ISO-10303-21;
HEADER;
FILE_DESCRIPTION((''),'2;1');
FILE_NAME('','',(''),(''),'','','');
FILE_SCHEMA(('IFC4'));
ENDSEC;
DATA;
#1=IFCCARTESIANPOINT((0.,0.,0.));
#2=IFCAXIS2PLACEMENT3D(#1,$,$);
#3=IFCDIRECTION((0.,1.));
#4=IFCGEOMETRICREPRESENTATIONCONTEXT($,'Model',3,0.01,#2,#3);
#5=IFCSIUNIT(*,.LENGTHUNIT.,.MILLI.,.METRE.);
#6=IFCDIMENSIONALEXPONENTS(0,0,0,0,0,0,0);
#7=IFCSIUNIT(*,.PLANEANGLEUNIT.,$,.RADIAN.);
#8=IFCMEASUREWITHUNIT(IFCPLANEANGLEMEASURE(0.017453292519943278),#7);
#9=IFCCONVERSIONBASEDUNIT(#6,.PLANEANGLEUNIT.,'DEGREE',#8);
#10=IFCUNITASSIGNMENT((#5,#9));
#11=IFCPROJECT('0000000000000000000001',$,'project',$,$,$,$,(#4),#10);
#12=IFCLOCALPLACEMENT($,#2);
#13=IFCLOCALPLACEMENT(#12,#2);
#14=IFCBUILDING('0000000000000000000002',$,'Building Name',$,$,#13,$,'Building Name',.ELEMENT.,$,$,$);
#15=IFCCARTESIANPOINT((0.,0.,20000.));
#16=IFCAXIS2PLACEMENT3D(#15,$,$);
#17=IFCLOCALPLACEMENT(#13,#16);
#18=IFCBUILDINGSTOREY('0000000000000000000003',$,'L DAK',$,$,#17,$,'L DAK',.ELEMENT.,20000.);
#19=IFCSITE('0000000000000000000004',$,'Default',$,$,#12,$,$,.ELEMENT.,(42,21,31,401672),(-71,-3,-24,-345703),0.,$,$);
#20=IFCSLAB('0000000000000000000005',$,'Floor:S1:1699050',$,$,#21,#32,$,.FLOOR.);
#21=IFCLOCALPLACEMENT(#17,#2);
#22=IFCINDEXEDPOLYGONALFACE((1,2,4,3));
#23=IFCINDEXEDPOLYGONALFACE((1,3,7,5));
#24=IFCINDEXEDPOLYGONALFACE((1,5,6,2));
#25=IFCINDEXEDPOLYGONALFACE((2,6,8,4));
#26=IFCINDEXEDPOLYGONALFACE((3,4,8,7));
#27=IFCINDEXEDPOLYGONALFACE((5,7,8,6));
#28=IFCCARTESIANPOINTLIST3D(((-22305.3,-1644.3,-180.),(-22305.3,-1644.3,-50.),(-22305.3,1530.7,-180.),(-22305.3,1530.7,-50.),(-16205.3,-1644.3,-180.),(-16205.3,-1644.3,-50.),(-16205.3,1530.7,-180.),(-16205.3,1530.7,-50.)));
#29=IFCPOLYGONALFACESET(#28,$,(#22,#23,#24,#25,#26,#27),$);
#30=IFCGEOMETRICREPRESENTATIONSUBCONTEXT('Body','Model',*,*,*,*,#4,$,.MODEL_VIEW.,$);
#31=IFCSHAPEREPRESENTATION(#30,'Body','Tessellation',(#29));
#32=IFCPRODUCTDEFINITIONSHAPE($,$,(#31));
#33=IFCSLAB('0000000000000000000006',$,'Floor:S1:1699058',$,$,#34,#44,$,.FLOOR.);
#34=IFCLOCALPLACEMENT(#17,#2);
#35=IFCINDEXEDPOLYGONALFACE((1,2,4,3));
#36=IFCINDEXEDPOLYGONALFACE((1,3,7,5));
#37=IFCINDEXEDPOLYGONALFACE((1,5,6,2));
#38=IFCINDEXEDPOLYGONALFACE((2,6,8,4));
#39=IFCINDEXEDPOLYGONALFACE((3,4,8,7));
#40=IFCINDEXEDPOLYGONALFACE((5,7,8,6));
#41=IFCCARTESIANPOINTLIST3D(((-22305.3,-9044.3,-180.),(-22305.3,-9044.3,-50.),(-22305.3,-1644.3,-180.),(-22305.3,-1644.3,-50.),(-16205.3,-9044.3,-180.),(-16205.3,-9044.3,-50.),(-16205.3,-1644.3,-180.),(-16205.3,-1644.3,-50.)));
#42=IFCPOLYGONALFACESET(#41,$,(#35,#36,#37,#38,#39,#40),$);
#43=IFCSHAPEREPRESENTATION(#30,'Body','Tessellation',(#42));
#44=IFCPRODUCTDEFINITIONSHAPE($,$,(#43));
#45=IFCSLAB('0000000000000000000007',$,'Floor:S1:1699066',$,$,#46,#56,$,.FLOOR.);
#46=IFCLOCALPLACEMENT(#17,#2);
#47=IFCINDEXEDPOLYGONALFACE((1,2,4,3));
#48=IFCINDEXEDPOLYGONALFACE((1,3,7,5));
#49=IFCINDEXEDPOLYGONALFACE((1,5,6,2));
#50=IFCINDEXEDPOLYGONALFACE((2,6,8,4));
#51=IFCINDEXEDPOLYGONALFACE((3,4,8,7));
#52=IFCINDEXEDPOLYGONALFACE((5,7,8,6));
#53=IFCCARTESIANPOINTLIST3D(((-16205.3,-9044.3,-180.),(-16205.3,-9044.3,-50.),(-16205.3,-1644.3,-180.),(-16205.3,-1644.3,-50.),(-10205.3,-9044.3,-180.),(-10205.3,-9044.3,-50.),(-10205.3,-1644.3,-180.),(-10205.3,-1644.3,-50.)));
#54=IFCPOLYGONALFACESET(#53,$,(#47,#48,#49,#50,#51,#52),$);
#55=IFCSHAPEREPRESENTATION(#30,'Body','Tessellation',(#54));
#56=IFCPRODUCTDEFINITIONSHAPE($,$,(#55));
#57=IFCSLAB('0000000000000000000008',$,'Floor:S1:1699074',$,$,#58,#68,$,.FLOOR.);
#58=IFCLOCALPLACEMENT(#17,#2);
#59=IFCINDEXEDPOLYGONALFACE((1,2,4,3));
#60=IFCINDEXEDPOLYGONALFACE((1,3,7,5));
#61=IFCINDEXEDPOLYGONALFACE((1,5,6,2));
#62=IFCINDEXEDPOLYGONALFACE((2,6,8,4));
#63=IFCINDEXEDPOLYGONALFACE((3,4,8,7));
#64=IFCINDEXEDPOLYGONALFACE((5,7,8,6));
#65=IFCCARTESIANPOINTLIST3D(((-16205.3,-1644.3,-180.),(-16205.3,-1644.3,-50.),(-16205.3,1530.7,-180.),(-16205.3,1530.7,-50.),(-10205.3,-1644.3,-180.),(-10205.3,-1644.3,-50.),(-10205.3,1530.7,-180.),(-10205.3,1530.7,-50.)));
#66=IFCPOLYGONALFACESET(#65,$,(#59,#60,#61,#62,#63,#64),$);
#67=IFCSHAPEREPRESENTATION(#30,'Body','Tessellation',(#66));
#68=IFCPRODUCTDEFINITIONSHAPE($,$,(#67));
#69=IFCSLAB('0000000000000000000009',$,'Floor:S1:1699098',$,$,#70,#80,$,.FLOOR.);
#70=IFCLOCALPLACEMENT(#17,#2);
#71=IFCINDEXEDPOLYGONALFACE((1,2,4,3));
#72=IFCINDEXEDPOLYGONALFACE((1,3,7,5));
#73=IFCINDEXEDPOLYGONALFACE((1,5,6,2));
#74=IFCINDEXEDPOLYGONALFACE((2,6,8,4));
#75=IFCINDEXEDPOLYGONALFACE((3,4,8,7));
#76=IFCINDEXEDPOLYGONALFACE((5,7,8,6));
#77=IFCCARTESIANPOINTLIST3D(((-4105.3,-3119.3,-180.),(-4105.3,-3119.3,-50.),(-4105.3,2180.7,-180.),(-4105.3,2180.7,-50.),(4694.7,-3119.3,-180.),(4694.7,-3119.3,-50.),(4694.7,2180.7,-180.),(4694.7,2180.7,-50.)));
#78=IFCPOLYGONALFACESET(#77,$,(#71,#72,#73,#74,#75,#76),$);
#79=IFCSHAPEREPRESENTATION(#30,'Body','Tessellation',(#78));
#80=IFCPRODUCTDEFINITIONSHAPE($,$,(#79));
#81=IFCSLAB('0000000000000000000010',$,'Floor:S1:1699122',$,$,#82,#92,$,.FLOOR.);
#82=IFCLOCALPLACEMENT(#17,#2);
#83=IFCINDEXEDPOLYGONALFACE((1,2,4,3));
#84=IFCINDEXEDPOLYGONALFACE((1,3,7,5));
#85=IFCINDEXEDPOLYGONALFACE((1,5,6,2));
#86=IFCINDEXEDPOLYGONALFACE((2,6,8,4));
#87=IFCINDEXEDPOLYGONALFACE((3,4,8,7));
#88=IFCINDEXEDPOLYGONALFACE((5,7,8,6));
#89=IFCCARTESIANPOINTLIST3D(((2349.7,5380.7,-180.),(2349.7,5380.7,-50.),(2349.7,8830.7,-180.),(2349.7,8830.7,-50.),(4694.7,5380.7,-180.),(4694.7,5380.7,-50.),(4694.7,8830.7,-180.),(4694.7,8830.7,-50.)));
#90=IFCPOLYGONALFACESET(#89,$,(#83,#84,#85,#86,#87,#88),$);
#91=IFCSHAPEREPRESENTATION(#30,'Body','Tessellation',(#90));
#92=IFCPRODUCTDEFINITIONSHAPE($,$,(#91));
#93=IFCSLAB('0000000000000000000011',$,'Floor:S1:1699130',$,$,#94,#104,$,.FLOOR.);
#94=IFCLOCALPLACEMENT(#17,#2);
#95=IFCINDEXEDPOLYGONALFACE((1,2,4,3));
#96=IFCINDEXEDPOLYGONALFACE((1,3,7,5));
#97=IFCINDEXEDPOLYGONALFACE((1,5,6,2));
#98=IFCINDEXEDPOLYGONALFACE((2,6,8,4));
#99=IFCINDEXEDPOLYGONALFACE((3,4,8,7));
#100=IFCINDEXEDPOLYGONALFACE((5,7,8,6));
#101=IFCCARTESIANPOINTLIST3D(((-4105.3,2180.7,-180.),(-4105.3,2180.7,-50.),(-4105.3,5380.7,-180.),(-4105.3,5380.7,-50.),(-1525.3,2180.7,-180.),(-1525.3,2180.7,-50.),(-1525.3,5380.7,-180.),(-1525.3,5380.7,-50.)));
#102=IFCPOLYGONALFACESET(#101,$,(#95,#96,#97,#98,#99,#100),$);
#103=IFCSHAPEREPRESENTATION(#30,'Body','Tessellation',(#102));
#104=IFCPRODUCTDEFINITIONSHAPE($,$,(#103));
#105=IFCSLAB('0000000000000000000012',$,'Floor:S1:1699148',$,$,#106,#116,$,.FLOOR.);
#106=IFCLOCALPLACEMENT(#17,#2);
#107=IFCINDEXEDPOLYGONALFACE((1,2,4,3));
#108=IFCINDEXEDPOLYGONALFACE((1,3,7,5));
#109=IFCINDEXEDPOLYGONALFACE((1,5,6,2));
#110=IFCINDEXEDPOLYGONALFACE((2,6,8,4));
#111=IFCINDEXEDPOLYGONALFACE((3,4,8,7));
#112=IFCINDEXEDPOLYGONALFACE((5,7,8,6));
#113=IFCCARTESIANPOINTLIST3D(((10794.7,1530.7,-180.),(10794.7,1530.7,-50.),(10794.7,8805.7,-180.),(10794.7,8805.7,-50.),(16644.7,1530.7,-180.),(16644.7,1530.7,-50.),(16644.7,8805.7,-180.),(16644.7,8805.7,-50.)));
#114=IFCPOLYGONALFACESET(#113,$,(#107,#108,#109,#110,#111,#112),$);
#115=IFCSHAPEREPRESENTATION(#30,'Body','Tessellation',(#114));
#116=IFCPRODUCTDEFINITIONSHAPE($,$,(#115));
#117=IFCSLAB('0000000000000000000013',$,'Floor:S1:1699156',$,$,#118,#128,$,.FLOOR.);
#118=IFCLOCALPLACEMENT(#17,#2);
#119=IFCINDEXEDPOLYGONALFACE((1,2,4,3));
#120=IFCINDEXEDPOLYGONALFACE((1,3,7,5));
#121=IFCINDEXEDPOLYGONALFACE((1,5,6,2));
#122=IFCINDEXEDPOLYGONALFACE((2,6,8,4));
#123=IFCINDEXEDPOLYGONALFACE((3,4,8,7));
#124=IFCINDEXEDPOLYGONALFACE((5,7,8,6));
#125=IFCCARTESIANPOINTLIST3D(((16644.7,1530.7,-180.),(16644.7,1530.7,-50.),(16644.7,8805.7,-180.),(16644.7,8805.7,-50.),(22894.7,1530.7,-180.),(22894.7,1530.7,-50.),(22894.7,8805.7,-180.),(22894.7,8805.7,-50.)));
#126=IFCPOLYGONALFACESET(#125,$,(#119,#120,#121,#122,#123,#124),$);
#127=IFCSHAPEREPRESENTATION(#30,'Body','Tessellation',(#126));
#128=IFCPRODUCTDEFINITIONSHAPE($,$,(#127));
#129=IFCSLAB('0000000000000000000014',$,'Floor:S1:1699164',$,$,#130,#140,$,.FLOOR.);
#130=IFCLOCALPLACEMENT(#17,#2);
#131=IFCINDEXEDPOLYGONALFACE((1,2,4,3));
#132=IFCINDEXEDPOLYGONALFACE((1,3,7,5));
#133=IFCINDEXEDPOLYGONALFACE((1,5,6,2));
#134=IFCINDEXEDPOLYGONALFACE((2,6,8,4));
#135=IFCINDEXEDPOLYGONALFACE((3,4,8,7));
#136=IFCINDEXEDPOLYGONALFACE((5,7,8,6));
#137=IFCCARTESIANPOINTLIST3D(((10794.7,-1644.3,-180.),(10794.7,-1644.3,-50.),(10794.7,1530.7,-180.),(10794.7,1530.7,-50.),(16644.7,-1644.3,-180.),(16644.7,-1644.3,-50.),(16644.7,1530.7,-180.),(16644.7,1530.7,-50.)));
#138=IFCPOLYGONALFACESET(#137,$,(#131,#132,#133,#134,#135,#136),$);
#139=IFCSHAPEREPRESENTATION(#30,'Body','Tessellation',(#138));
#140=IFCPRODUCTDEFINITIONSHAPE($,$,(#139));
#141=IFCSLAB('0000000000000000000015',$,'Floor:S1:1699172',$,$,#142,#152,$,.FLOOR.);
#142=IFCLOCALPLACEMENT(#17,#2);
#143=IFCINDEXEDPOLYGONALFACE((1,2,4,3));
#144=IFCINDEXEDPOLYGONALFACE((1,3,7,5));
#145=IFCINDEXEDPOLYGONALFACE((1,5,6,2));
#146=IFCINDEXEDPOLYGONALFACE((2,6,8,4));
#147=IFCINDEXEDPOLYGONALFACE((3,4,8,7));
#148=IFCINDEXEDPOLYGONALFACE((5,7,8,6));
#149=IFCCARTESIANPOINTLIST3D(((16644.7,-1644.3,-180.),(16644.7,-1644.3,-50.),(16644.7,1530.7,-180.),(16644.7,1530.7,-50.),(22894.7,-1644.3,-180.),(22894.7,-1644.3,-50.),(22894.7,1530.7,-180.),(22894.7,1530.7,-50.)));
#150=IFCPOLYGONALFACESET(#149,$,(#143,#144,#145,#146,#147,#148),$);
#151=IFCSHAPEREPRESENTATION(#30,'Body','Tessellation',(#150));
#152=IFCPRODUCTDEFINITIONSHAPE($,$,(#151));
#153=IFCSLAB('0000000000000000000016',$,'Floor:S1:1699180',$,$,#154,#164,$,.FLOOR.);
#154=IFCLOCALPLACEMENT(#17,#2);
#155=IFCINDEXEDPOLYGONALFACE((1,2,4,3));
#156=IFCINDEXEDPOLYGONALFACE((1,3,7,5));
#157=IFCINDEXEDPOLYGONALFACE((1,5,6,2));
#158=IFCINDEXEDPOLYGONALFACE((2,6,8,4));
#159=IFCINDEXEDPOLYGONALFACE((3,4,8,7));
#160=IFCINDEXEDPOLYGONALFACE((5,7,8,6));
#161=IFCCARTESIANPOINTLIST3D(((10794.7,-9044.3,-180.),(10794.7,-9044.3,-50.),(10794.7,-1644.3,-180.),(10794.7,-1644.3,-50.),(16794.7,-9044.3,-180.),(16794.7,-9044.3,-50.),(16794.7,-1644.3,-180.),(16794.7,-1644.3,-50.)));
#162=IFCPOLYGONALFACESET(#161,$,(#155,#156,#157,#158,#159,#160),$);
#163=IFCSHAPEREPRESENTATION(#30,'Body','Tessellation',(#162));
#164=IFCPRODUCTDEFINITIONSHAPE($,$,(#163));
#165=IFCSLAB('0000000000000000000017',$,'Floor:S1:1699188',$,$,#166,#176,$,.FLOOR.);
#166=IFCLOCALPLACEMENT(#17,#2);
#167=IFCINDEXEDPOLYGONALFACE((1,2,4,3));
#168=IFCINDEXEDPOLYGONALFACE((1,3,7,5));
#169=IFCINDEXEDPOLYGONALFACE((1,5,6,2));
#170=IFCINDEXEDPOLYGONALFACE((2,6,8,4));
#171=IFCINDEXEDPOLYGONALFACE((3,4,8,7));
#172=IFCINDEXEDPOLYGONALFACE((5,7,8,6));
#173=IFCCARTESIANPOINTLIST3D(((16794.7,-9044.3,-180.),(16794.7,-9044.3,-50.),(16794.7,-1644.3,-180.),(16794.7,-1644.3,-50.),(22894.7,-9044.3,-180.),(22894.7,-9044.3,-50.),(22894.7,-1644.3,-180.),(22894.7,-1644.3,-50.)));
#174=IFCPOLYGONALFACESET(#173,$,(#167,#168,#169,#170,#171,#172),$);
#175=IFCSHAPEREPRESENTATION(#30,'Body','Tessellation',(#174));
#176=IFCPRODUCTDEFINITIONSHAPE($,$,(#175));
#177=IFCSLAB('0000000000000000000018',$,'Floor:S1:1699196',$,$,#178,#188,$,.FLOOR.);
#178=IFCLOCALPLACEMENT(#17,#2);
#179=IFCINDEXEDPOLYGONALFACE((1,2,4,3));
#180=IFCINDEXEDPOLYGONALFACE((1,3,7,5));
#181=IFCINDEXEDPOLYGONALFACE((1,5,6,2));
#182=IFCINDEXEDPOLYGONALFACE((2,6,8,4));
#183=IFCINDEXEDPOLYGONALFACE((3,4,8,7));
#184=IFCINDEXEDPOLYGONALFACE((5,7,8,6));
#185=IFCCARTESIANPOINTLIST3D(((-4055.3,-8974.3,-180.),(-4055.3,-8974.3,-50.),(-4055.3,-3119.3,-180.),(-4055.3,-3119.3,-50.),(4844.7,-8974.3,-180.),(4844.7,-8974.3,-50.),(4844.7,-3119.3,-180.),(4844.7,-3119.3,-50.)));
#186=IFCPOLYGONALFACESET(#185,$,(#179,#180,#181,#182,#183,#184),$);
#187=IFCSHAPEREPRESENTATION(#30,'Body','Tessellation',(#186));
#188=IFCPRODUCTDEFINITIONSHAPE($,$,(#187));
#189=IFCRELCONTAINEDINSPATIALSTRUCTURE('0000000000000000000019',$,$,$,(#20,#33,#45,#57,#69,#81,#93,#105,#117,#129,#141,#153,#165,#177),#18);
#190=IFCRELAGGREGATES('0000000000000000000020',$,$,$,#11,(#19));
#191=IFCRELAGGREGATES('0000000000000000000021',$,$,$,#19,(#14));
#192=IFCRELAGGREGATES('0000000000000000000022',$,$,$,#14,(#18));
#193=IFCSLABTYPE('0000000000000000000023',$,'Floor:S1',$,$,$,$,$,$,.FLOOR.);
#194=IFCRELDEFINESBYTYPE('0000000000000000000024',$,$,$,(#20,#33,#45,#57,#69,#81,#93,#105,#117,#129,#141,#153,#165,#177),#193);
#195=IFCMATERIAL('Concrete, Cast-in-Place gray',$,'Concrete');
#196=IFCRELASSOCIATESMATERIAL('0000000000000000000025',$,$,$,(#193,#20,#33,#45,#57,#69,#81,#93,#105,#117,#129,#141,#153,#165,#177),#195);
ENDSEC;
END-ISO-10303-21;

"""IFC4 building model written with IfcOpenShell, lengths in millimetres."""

from ifc_helpers import new_model, entity, si_unit, converted_unit, direction, frame, origin, place, context, subcontext, project, spatial, indexed_curve, outline, extrude, material, type_object, element, save


model = new_model("IFC4")

# Units and contexts
model_context = context("Model", 3, precision=0.01, world=origin(), true_north=direction((0.0, 1.0)))
body_context = subcontext(model_context, "Body", "Model", "MODEL_VIEW")
ifc_project = project(units=[si_unit("LENGTHUNIT", "METRE", prefix="MILLI"), converted_unit("PLANEANGLEUNIT", "DEGREE", entity("IfcPlaneAngleMeasure", 0.017453292519943278), si_unit("PLANEANGLEUNIT", "RADIAN"), dimensions=[0, 0, 0, 0, 0, 0, 0])], contexts=[model_context])

# Site, building, storey
site_placement = place(None, origin())
site = spatial("IfcSite", under=ifc_project, at=site_placement, Name="Default", CompositionType="ELEMENT", RefLatitude=(42, 21, 31, 401672), RefLongitude=(-71, -3, -24, -345703), RefElevation=0.0)
building_placement = place(site_placement, origin())
building = spatial("IfcBuilding", under=site, at=building_placement, Name="Building Name", LongName="Building Name", CompositionType="ELEMENT")
storey_placement = place(building_placement, frame((0.0, 0.0, 20000.0)))
storey = spatial("IfcBuildingStorey", under=building, at=storey_placement, Name="L DAK", LongName="L DAK", CompositionType="ELEMENT", Elevation=20000.0)

# Slabs
ifc_material = material(Name="Concrete, Cast-in-Place gray", Category="Concrete")
slab_type = type_object("IfcSlabType", Name="Floor:S1", PredefinedType="FLOOR", material=ifc_material)
slab_1_placement = place(storey_placement, origin())
element("IfcSlab", 1, at=slab_1_placement, inside=storey, type_object=slab_type, material=ifc_material, Name="Floor:S1:1699050", PredefinedType="FLOOR", context=body_context, shape_type="SweptSolid", body=[
    extrude(outline(indexed_curve([(-1587.5, -3050.0), (1587.5, -3050.0), (1587.5, 3050.0), (-1587.5, 3050.0), (-1587.5, -3050.0)], self_intersect=False)), frame((-19255.3, -56.8, -50.0), z_axis=(0.0, 0.0, -1.0), x_axis=(0.0, 1.0, 0.0)), (0.0, 0.0, 1.0), 130.0),
])
slab_2_placement = place(storey_placement, origin())
element("IfcSlab", 2, at=slab_2_placement, inside=storey, type_object=slab_type, material=ifc_material, Name="Floor:S1:1699058", PredefinedType="FLOOR", context=body_context, shape_type="SweptSolid", body=[
    extrude(outline(indexed_curve([(-3700.0, -3050.0), (3700.0, -3050.0), (3700.0, 3050.0), (-3700.0, 3050.0), (-3700.0, -3050.0)], self_intersect=False)), frame((-19255.3, -5344.3, -50.0), z_axis=(0.0, 0.0, -1.0), x_axis=(0.0, 1.0, 0.0)), (0.0, 0.0, 1.0), 130.0),
])
slab_3_placement = place(storey_placement, origin())
element("IfcSlab", 3, at=slab_3_placement, inside=storey, type_object=slab_type, material=ifc_material, Name="Floor:S1:1699066", PredefinedType="FLOOR", context=body_context, shape_type="SweptSolid", body=[
    extrude(outline(indexed_curve([(-3700.0, -3000.0), (3700.0, -3000.0), (3700.0, 3000.0), (-3700.0, 3000.0), (-3700.0, -3000.0)], self_intersect=False)), frame((-13205.3, -5344.3, -50.0), z_axis=(0.0, 0.0, -1.0), x_axis=(0.0, 1.0, 0.0)), (0.0, 0.0, 1.0), 130.0),
])
slab_4_placement = place(storey_placement, origin())
element("IfcSlab", 4, at=slab_4_placement, inside=storey, type_object=slab_type, material=ifc_material, Name="Floor:S1:1699074", PredefinedType="FLOOR", context=body_context, shape_type="SweptSolid", body=[
    extrude(outline(indexed_curve([(-1587.5, -3000.0), (1587.5, -3000.0), (1587.5, 3000.0), (-1587.5, 3000.0), (-1587.5, -3000.0)], self_intersect=False)), frame((-13205.3, -56.8, -50.0), z_axis=(0.0, 0.0, -1.0), x_axis=(0.0, 1.0, 0.0)), (0.0, 0.0, 1.0), 130.0),
])
slab_5_placement = place(storey_placement, origin())
element("IfcSlab", 5, at=slab_5_placement, inside=storey, type_object=slab_type, material=ifc_material, Name="Floor:S1:1699098", PredefinedType="FLOOR", context=body_context, shape_type="SweptSolid", body=[
    extrude(outline(indexed_curve([(-2650.0, -4400.0), (2650.0, -4400.0), (2650.0, 4400.0), (-2650.0, 4400.0), (-2650.0, -4400.0)], self_intersect=False)), frame((294.7, -469.3, -50.0), z_axis=(0.0, 0.0, -1.0), x_axis=(0.0, 1.0, 0.0)), (0.0, 0.0, 1.0), 130.0),
])
slab_6_placement = place(storey_placement, origin())
element("IfcSlab", 6, at=slab_6_placement, inside=storey, type_object=slab_type, material=ifc_material, Name="Floor:S1:1699122", PredefinedType="FLOOR", context=body_context, shape_type="SweptSolid", body=[
    extrude(outline(indexed_curve([(-1725.0, -1172.5), (1725.0, -1172.5), (1725.0, 1172.5), (-1725.0, 1172.5), (-1725.0, -1172.5)], self_intersect=False)), frame((3522.2, 7105.7, -50.0), z_axis=(0.0, 0.0, -1.0), x_axis=(0.0, 1.0, 0.0)), (0.0, 0.0, 1.0), 130.0),
])
slab_7_placement = place(storey_placement, origin())
element("IfcSlab", 7, at=slab_7_placement, inside=storey, type_object=slab_type, material=ifc_material, Name="Floor:S1:1699130", PredefinedType="FLOOR", context=body_context, shape_type="SweptSolid", body=[
    extrude(outline(indexed_curve([(-1600.0, -1290.0), (1600.0, -1290.0), (1600.0, 1290.0), (-1600.0, 1290.0), (-1600.0, -1290.0)], self_intersect=False)), frame((-2815.3, 3780.7, -50.0), z_axis=(0.0, 0.0, -1.0), x_axis=(0.0, 1.0, 0.0)), (0.0, 0.0, 1.0), 130.0),
])
slab_8_placement = place(storey_placement, origin())
element("IfcSlab", 8, at=slab_8_placement, inside=storey, type_object=slab_type, material=ifc_material, Name="Floor:S1:1699148", PredefinedType="FLOOR", context=body_context, shape_type="SweptSolid", body=[
    extrude(outline(indexed_curve([(-3637.5, -2925.0), (3637.5, -2925.0), (3637.5, 2925.0), (-3637.5, 2925.0), (-3637.5, -2925.0)], self_intersect=False)), frame((13719.7, 5168.2, -50.0), z_axis=(0.0, 0.0, -1.0), x_axis=(0.0, 1.0, 0.0)), (0.0, 0.0, 1.0), 130.0),
])
slab_9_placement = place(storey_placement, origin())
element("IfcSlab", 9, at=slab_9_placement, inside=storey, type_object=slab_type, material=ifc_material, Name="Floor:S1:1699156", PredefinedType="FLOOR", context=body_context, shape_type="SweptSolid", body=[
    extrude(outline(indexed_curve([(-3637.5, -3125.0), (3637.5, -3125.0), (3637.5, 3125.0), (-3637.5, 3125.0), (-3637.5, -3125.0)], self_intersect=False)), frame((19769.7, 5168.2, -50.0), z_axis=(0.0, 0.0, -1.0), x_axis=(0.0, 1.0, 0.0)), (0.0, 0.0, 1.0), 130.0),
])
slab_10_placement = place(storey_placement, origin())
element("IfcSlab", 10, at=slab_10_placement, inside=storey, type_object=slab_type, material=ifc_material, Name="Floor:S1:1699164", PredefinedType="FLOOR", context=body_context, shape_type="SweptSolid", body=[
    extrude(outline(indexed_curve([(-1587.5, -2925.0), (1587.5, -2925.0), (1587.5, 2925.0), (-1587.5, 2925.0), (-1587.5, -2925.0)], self_intersect=False)), frame((13719.7, -56.8, -50.0), z_axis=(0.0, 0.0, -1.0), x_axis=(0.0, 1.0, 0.0)), (0.0, 0.0, 1.0), 130.0),
])
slab_11_placement = place(storey_placement, origin())
element("IfcSlab", 11, at=slab_11_placement, inside=storey, type_object=slab_type, material=ifc_material, Name="Floor:S1:1699172", PredefinedType="FLOOR", context=body_context, shape_type="SweptSolid", body=[
    extrude(outline(indexed_curve([(-1587.5, -3125.0), (1587.5, -3125.0), (1587.5, 3125.0), (-1587.5, 3125.0), (-1587.5, -3125.0)], self_intersect=False)), frame((19769.7, -56.8, -50.0), z_axis=(0.0, 0.0, -1.0), x_axis=(0.0, 1.0, 0.0)), (0.0, 0.0, 1.0), 130.0),
])
slab_12_placement = place(storey_placement, origin())
element("IfcSlab", 12, at=slab_12_placement, inside=storey, type_object=slab_type, material=ifc_material, Name="Floor:S1:1699180", PredefinedType="FLOOR", context=body_context, shape_type="SweptSolid", body=[
    extrude(outline(indexed_curve([(-3700.0, -3000.0), (3700.0, -3000.0), (3700.0, 3000.0), (-3700.0, 3000.0), (-3700.0, -3000.0)], self_intersect=False)), frame((13794.7, -5344.3, -50.0), z_axis=(0.0, 0.0, -1.0), x_axis=(0.0, 1.0, 0.0)), (0.0, 0.0, 1.0), 130.0),
])
slab_13_placement = place(storey_placement, origin())
element("IfcSlab", 13, at=slab_13_placement, inside=storey, type_object=slab_type, material=ifc_material, Name="Floor:S1:1699188", PredefinedType="FLOOR", context=body_context, shape_type="SweptSolid", body=[
    extrude(outline(indexed_curve([(-3700.0, -3050.0), (3700.0, -3050.0), (3700.0, 3050.0), (-3700.0, 3050.0), (-3700.0, -3050.0)], self_intersect=False)), frame((19844.7, -5344.3, -50.0), z_axis=(0.0, 0.0, -1.0), x_axis=(0.0, 1.0, 0.0)), (0.0, 0.0, 1.0), 130.0),
])
slab_14_placement = place(storey_placement, origin())
element("IfcSlab", 14, at=slab_14_placement, inside=storey, type_object=slab_type, material=ifc_material, Name="Floor:S1:1699196", PredefinedType="FLOOR", context=body_context, shape_type="SweptSolid", body=[
    extrude(outline(indexed_curve([(-2927.5, -4450.0), (2927.5, -4450.0), (2927.5, 4450.0), (-2927.5, 4450.0), (-2927.5, -4450.0)], self_intersect=False)), frame((394.7, -6046.8, -50.0), z_axis=(0.0, 0.0, -1.0), x_axis=(0.0, 1.0, 0.0)), (0.0, 0.0, 1.0), 130.0),
])

save(model, "model.ifc")
